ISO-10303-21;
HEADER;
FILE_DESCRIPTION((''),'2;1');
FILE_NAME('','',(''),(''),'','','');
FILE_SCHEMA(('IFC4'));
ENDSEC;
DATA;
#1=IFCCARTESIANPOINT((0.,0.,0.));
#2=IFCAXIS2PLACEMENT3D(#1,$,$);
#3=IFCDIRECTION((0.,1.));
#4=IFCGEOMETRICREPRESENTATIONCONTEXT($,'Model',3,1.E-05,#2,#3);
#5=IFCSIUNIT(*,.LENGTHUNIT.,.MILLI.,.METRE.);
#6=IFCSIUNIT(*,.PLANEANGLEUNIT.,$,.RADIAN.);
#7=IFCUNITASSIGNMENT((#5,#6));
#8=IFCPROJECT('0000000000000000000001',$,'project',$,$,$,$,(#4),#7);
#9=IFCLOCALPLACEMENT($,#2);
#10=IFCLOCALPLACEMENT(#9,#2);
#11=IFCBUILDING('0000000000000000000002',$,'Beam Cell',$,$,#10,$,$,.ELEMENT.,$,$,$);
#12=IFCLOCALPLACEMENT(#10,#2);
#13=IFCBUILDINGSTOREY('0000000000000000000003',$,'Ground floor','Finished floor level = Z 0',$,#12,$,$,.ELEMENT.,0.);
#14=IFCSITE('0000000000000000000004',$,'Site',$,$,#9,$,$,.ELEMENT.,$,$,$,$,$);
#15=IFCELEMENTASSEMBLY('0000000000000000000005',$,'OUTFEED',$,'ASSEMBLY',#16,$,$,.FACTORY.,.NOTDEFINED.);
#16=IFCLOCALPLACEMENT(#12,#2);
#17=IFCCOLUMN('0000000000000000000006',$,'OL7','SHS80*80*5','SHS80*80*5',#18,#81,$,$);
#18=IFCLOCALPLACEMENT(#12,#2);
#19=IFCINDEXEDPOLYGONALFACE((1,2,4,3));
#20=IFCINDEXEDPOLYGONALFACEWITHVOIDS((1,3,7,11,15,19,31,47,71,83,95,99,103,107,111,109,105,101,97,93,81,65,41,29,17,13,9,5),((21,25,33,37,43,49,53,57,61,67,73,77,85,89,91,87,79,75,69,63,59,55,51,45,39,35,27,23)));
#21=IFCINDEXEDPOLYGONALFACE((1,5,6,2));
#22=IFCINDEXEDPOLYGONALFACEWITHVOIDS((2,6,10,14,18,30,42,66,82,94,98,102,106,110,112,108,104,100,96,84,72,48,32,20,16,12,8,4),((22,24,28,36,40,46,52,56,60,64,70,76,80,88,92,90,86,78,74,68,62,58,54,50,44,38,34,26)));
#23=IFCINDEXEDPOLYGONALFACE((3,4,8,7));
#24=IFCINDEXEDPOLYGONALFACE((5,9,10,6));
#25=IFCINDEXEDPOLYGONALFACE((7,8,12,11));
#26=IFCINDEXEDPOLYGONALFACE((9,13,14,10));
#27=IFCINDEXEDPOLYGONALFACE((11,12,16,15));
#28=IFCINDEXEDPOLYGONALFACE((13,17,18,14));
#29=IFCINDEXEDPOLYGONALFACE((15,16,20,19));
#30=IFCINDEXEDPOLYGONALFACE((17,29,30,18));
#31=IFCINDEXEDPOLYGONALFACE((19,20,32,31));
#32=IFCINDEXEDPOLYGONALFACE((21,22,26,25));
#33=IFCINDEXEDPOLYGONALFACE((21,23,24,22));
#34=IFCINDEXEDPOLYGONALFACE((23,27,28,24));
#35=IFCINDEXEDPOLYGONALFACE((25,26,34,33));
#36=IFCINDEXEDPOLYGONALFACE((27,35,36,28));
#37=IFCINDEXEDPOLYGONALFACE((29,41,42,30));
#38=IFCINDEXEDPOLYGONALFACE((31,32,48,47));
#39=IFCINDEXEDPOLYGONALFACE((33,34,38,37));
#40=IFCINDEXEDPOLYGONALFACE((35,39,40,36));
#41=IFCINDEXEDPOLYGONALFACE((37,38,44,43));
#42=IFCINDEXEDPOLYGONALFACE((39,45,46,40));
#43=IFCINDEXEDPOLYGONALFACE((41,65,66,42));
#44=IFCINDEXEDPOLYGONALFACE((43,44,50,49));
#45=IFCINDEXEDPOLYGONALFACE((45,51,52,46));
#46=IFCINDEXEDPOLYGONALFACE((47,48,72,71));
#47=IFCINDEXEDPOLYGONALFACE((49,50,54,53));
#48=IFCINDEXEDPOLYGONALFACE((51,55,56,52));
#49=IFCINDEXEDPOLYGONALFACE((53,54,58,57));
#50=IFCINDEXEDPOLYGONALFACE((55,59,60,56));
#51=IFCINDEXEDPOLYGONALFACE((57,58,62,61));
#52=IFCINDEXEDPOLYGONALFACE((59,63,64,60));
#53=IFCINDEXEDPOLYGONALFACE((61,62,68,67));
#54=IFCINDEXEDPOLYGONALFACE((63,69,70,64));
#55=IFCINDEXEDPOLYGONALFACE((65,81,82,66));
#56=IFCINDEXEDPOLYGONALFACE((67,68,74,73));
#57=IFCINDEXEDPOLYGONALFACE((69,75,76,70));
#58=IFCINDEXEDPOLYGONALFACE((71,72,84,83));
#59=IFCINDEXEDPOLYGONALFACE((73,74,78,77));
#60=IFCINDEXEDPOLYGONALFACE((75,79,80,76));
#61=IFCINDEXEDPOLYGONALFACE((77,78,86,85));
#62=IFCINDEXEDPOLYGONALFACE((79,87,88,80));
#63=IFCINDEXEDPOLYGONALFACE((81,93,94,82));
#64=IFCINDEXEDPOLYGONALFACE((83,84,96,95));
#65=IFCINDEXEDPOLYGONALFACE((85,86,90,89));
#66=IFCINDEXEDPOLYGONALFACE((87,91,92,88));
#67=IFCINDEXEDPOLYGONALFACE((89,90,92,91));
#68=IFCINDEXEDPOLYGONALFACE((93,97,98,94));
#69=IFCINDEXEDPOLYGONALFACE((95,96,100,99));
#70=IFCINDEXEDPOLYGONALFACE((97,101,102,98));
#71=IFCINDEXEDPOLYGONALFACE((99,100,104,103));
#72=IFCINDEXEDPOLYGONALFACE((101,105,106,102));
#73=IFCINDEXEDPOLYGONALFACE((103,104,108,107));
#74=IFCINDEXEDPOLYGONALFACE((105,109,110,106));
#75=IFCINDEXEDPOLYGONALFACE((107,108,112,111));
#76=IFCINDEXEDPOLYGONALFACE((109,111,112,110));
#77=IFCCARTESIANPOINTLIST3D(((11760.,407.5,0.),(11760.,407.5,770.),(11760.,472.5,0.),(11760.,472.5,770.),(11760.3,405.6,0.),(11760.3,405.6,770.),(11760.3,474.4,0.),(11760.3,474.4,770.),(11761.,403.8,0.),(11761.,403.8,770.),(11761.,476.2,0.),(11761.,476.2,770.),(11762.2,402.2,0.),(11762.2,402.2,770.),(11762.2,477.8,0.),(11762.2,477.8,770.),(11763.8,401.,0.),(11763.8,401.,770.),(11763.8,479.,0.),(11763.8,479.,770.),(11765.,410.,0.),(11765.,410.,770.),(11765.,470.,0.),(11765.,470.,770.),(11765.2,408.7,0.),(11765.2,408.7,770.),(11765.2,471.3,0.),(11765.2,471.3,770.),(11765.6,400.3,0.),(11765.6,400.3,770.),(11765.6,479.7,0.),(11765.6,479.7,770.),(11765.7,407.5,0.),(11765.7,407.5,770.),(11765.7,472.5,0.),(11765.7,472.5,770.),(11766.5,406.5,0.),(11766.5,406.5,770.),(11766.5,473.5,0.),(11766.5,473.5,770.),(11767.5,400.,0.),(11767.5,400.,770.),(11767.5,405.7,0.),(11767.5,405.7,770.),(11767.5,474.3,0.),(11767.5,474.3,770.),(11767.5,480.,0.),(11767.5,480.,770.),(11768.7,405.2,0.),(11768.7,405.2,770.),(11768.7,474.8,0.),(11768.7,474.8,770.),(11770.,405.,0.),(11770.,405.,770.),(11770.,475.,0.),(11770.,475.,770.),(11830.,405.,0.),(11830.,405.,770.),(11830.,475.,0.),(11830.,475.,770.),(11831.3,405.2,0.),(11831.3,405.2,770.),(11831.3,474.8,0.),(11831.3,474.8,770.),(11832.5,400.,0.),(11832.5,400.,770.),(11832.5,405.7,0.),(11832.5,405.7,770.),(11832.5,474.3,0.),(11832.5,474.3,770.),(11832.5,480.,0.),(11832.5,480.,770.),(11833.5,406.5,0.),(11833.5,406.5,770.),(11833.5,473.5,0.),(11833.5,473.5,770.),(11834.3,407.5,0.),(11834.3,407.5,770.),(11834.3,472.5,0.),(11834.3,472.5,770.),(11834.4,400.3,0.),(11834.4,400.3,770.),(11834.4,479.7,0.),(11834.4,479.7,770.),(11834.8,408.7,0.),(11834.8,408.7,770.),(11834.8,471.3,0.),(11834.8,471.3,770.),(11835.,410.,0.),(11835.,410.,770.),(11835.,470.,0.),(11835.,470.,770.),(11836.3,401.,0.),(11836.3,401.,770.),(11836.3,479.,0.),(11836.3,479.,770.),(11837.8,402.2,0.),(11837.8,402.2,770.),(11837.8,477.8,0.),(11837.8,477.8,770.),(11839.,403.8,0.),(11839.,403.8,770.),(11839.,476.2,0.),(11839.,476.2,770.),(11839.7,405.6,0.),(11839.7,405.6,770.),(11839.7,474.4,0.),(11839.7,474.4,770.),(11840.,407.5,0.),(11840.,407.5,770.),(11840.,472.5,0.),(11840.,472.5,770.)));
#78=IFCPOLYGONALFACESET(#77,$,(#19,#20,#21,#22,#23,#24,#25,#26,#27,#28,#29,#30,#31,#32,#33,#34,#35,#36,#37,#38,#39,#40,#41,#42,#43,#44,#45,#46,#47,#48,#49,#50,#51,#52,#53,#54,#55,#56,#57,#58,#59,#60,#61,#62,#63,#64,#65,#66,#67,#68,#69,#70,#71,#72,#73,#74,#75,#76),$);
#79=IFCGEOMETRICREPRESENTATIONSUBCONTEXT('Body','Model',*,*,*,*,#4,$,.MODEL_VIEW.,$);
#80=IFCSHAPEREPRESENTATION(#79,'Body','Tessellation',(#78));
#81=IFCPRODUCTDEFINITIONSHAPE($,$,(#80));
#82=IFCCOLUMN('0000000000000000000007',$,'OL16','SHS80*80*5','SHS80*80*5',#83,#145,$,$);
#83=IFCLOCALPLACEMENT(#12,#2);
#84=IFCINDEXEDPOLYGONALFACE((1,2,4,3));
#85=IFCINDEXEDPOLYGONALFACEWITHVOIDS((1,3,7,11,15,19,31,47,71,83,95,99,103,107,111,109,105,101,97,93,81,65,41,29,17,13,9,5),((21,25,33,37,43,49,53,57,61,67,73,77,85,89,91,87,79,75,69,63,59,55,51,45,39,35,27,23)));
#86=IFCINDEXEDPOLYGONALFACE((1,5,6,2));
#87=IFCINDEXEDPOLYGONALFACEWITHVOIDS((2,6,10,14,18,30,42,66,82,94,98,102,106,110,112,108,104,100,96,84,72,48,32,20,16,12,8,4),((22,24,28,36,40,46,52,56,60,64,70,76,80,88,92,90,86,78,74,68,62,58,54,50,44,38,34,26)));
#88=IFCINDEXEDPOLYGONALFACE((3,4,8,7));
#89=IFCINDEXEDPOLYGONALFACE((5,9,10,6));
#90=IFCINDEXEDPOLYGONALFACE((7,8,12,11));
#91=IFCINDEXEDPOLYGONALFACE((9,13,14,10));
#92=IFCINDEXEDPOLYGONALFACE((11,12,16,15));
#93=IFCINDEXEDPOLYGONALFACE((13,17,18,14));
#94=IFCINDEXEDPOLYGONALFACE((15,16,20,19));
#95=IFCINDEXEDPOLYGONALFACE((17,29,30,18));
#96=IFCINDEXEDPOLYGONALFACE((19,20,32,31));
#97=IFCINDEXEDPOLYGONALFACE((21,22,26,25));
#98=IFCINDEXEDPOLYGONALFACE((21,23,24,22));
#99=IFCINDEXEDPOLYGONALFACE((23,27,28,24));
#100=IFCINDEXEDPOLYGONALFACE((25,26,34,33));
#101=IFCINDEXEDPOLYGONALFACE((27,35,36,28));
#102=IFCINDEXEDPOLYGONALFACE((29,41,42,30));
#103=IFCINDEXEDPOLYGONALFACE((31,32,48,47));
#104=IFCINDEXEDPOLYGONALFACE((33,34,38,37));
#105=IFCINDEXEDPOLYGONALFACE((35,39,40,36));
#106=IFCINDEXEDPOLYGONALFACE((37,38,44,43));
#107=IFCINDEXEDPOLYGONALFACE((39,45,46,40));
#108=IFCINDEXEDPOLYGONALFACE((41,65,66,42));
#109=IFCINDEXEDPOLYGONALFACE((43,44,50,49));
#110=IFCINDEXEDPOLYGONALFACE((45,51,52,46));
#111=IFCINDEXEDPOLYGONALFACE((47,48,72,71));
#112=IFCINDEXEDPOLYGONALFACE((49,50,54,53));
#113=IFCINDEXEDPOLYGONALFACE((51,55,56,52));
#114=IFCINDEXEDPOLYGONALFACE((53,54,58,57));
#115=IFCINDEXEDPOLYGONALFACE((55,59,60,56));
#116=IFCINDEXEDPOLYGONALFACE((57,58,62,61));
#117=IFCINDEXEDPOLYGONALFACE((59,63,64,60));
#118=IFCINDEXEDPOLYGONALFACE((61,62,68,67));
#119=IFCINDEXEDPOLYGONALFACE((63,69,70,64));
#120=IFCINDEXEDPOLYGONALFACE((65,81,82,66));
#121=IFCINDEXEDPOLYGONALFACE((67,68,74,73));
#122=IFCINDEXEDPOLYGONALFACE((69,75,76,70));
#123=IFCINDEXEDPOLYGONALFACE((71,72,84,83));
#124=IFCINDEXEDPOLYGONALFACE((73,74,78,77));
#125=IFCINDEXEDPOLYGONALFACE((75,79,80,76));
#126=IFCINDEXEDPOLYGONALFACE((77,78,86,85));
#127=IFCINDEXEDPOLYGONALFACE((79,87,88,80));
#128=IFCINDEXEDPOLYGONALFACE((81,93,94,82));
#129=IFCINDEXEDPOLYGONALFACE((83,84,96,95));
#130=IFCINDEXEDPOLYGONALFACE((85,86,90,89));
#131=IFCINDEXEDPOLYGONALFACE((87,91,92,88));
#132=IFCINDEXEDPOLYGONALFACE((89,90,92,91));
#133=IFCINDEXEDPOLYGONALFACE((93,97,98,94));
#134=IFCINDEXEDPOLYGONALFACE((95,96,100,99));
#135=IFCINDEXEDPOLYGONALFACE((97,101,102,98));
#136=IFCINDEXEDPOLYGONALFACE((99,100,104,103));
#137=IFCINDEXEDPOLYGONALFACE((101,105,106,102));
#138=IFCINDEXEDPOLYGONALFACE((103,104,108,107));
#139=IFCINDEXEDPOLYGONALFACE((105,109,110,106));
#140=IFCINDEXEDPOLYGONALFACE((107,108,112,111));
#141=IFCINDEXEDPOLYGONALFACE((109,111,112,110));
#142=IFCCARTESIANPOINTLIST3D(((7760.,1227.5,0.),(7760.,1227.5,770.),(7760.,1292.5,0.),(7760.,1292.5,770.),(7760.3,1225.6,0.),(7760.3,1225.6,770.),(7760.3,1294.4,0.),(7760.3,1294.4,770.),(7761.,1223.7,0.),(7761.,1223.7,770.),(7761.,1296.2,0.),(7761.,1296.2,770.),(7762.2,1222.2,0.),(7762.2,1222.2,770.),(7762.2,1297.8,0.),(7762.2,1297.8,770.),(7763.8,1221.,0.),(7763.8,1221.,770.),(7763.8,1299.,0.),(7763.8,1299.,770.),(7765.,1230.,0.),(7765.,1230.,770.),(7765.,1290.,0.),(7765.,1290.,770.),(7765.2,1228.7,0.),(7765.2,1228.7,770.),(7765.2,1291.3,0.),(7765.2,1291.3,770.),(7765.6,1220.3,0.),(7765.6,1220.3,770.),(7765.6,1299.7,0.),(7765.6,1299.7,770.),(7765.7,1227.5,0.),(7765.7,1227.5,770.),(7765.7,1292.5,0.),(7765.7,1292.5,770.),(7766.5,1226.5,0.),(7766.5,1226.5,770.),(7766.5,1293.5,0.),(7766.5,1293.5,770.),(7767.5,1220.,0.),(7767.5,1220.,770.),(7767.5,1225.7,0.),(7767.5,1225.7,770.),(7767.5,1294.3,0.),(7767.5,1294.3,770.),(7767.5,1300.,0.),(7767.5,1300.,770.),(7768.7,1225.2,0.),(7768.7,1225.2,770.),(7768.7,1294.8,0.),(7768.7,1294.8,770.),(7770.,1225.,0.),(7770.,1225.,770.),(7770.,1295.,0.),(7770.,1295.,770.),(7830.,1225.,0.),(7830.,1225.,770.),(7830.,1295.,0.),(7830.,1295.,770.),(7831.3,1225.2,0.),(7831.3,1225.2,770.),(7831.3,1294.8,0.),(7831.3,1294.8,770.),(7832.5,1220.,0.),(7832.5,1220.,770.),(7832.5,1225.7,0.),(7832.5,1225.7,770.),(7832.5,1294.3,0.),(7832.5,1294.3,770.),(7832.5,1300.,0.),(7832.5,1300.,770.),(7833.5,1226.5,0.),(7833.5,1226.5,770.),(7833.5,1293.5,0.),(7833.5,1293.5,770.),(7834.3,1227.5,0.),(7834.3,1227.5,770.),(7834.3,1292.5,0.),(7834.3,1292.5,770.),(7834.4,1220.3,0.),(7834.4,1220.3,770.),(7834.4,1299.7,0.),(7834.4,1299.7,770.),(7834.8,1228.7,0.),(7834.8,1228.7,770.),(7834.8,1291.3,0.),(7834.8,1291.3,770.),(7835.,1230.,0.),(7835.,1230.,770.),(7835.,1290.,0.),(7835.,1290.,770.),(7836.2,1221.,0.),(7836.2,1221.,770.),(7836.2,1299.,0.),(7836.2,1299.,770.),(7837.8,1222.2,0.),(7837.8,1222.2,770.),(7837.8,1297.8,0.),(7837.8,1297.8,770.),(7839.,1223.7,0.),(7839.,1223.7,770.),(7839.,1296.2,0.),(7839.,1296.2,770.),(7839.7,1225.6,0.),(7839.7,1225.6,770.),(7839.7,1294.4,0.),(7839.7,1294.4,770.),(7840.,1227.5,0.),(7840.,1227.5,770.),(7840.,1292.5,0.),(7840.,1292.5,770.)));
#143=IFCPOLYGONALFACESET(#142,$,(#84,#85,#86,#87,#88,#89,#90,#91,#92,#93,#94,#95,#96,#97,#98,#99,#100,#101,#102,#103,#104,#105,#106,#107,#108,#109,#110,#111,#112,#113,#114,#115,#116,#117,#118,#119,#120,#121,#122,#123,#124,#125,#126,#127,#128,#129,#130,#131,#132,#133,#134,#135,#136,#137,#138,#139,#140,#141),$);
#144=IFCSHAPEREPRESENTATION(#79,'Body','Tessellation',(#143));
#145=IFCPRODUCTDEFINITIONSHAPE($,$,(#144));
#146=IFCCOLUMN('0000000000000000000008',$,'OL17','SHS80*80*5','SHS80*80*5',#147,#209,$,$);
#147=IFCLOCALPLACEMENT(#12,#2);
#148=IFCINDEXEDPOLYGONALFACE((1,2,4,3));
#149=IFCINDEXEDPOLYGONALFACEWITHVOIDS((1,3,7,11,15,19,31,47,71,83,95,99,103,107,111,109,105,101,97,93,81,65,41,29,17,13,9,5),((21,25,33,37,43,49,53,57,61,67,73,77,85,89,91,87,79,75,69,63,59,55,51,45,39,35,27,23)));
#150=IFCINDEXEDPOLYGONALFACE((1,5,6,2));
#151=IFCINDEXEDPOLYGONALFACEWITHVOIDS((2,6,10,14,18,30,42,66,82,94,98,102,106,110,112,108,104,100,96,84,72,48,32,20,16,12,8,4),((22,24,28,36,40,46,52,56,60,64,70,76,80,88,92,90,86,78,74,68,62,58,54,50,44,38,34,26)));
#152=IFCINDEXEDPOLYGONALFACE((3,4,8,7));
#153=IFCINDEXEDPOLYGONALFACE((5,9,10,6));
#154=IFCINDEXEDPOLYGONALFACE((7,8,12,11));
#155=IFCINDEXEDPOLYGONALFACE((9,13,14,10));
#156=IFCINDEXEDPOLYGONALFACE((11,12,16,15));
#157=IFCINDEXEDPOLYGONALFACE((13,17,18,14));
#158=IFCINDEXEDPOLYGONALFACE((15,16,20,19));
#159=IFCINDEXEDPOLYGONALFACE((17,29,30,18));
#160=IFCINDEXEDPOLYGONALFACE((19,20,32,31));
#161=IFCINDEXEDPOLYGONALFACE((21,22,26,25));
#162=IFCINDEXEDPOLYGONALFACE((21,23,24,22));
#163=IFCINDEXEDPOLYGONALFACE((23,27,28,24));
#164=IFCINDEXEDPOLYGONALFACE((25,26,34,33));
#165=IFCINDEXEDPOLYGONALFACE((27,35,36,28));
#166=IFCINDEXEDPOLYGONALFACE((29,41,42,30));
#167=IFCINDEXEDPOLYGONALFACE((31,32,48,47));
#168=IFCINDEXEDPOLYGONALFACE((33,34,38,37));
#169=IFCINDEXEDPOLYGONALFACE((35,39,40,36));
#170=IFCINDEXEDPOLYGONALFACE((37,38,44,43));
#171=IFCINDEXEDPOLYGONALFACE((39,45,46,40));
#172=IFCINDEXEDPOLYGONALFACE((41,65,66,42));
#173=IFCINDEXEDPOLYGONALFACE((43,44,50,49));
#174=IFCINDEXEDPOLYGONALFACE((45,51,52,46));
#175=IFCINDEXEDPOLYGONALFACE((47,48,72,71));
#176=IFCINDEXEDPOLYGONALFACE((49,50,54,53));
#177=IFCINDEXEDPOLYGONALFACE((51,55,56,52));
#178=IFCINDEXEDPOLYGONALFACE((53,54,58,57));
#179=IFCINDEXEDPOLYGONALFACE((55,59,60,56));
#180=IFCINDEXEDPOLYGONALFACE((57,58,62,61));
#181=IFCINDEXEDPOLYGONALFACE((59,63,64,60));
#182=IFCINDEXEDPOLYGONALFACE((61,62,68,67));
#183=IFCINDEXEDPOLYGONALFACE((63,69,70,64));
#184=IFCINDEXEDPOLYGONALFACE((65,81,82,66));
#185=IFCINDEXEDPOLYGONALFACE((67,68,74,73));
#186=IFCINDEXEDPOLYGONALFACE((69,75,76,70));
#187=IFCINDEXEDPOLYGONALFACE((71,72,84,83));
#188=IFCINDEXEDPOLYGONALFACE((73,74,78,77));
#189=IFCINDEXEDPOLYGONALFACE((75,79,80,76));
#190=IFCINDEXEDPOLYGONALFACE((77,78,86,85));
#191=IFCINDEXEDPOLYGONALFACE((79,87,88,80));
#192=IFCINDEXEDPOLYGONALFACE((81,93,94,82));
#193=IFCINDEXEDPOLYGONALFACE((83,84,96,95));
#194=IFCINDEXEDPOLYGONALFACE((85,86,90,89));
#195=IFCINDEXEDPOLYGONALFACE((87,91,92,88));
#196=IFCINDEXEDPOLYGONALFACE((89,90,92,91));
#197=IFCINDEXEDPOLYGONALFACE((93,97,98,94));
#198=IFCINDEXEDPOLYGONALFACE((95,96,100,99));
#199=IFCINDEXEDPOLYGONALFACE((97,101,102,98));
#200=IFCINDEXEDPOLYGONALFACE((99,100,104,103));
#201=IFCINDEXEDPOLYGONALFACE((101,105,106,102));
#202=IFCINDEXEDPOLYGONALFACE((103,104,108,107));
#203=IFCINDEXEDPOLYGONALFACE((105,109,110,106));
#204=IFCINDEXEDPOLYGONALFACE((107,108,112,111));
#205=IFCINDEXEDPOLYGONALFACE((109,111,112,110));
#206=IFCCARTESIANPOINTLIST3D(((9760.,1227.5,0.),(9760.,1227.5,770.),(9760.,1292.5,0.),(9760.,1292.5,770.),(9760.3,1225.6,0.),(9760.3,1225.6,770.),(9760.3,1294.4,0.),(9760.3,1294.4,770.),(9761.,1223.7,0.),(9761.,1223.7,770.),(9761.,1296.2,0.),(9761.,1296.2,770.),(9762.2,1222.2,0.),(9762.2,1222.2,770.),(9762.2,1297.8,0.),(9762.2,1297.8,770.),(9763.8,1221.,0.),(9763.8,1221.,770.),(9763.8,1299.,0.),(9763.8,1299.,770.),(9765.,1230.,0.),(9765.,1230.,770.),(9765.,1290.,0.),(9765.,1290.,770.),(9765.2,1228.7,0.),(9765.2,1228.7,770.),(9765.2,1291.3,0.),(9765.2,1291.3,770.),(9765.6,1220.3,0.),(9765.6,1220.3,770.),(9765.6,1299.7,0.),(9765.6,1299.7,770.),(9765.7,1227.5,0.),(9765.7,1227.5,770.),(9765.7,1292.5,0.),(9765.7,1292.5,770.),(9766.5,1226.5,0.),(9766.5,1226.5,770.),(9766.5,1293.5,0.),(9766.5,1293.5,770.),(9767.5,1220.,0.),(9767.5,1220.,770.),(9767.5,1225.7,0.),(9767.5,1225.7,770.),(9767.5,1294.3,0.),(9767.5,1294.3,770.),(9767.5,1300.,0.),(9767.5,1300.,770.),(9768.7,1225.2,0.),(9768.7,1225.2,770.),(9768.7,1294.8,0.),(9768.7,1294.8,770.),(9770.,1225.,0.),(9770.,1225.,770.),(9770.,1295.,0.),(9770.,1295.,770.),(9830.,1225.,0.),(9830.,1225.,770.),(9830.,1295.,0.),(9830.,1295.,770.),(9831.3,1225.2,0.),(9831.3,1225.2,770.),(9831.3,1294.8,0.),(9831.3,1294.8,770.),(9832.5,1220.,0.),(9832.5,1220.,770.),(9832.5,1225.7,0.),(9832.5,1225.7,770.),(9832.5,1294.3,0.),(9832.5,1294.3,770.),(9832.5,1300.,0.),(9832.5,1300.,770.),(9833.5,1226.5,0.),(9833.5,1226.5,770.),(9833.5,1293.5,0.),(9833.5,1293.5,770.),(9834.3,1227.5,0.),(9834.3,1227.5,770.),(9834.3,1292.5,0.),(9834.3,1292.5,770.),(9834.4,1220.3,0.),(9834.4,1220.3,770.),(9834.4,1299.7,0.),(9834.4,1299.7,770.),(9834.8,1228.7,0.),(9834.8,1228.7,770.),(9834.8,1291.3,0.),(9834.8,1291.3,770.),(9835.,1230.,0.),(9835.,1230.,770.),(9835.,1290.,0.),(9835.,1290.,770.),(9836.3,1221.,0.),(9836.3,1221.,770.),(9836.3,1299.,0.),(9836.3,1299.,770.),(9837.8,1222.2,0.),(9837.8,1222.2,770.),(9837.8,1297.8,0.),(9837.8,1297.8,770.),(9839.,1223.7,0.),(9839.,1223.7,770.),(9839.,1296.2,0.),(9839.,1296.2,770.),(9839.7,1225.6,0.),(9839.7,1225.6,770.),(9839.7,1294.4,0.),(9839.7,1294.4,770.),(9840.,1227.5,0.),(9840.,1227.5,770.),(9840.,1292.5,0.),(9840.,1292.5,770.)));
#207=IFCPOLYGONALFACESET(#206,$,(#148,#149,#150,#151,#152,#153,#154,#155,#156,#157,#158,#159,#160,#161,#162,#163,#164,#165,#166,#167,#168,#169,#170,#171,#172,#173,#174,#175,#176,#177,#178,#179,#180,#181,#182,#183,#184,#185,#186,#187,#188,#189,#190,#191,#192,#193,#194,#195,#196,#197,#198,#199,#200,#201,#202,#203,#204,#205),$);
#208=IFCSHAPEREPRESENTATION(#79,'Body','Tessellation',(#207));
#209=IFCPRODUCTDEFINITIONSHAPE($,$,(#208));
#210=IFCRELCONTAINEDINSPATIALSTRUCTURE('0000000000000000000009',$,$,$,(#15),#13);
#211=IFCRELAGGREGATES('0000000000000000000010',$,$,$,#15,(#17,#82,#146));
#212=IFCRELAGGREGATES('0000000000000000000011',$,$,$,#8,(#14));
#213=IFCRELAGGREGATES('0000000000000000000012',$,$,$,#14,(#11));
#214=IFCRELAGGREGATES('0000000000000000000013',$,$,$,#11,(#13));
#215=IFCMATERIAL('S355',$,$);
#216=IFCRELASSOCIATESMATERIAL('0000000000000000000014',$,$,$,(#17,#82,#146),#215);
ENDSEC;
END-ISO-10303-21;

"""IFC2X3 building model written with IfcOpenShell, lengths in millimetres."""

from ifc_helpers import new_model, si_unit, direction, frame, origin, origin_2d, place, context, subcontext, project, spatial, hollow_rectangle, extrude, material, element, aggregate, save


model = new_model("IFC2X3")

# Units and contexts
model_context = context("Model", 3, precision=1e-05, world=origin(), true_north=direction((0.0, 1.0)))
body_context = subcontext(model_context, "Body", "Model", "MODEL_VIEW")
ifc_project = project(units=[si_unit("LENGTHUNIT", "METRE", prefix="MILLI"), si_unit("PLANEANGLEUNIT", "RADIAN")], contexts=[model_context])

# Site, building, storey
site_placement = place(None, origin())
site = spatial("IfcSite", under=ifc_project, at=site_placement, Name="Site", CompositionType="ELEMENT")
building_placement = place(site_placement, origin())
building = spatial("IfcBuilding", under=site, at=building_placement, Name="Beam Cell", CompositionType="ELEMENT")
storey_placement = place(building_placement, origin())
storey = spatial("IfcBuildingStorey", under=building, at=storey_placement, Name="Ground floor", Description="Finished floor level = Z 0", CompositionType="ELEMENT", Elevation=0.0)

# Element assembly, columns
ifc_material = material(Name="S355")
assembly_1_placement = place(storey_placement, origin())
assembly_1 = element("IfcElementAssembly", 1, at=assembly_1_placement, inside=storey, Name="OUTFEED", ObjectType="ASSEMBLY", AssemblyPlace="FACTORY", PredefinedType="NOTDEFINED")
column_1_placement = place(storey_placement, frame((11800.0, 440.0, 0.0), z_axis=(0.0, 0.0, 1.0), x_axis=(1.0, 0.0, 0.0)))
column_1 = element("IfcColumn", 2, at=column_1_placement, material=ifc_material, Name="OL7", Description="SHS80*80*5", ObjectType="SHS80*80*5", context=body_context, shape_type="SweptSolid", body=[
    extrude(hollow_rectangle(XDim=80.0, YDim=80.0, WallThickness=5.0, InnerFilletRadius=5.0, OuterFilletRadius=7.5, at=origin_2d()), origin(), (0.0, 0.0, 1.0), 770.0),
])
column_2_placement = place(storey_placement, frame((7800.0, 1260.0, 0.0), z_axis=(0.0, 0.0, 1.0), x_axis=(1.0, 0.0, 0.0)))
column_2 = element("IfcColumn", 3, at=column_2_placement, material=ifc_material, Name="OL16", Description="SHS80*80*5", ObjectType="SHS80*80*5", context=body_context, shape_type="SweptSolid", body=[
    extrude(hollow_rectangle(XDim=80.0, YDim=80.0, WallThickness=5.0, InnerFilletRadius=5.0, OuterFilletRadius=7.5, at=origin_2d()), origin(), (0.0, 0.0, 1.0), 770.0),
])
column_3_placement = place(storey_placement, frame((9800.0, 1260.0, 0.0), z_axis=(0.0, 0.0, 1.0), x_axis=(1.0, 0.0, 0.0)))
column_3 = element("IfcColumn", 4, at=column_3_placement, material=ifc_material, Name="OL17", Description="SHS80*80*5", ObjectType="SHS80*80*5", context=body_context, shape_type="SweptSolid", body=[
    extrude(hollow_rectangle(XDim=80.0, YDim=80.0, WallThickness=5.0, InnerFilletRadius=5.0, OuterFilletRadius=7.5, at=origin_2d()), origin(), (0.0, 0.0, 1.0), 770.0),
])

aggregate(assembly_1, [column_1, column_2, column_3])

save(model, "model.ifc")
